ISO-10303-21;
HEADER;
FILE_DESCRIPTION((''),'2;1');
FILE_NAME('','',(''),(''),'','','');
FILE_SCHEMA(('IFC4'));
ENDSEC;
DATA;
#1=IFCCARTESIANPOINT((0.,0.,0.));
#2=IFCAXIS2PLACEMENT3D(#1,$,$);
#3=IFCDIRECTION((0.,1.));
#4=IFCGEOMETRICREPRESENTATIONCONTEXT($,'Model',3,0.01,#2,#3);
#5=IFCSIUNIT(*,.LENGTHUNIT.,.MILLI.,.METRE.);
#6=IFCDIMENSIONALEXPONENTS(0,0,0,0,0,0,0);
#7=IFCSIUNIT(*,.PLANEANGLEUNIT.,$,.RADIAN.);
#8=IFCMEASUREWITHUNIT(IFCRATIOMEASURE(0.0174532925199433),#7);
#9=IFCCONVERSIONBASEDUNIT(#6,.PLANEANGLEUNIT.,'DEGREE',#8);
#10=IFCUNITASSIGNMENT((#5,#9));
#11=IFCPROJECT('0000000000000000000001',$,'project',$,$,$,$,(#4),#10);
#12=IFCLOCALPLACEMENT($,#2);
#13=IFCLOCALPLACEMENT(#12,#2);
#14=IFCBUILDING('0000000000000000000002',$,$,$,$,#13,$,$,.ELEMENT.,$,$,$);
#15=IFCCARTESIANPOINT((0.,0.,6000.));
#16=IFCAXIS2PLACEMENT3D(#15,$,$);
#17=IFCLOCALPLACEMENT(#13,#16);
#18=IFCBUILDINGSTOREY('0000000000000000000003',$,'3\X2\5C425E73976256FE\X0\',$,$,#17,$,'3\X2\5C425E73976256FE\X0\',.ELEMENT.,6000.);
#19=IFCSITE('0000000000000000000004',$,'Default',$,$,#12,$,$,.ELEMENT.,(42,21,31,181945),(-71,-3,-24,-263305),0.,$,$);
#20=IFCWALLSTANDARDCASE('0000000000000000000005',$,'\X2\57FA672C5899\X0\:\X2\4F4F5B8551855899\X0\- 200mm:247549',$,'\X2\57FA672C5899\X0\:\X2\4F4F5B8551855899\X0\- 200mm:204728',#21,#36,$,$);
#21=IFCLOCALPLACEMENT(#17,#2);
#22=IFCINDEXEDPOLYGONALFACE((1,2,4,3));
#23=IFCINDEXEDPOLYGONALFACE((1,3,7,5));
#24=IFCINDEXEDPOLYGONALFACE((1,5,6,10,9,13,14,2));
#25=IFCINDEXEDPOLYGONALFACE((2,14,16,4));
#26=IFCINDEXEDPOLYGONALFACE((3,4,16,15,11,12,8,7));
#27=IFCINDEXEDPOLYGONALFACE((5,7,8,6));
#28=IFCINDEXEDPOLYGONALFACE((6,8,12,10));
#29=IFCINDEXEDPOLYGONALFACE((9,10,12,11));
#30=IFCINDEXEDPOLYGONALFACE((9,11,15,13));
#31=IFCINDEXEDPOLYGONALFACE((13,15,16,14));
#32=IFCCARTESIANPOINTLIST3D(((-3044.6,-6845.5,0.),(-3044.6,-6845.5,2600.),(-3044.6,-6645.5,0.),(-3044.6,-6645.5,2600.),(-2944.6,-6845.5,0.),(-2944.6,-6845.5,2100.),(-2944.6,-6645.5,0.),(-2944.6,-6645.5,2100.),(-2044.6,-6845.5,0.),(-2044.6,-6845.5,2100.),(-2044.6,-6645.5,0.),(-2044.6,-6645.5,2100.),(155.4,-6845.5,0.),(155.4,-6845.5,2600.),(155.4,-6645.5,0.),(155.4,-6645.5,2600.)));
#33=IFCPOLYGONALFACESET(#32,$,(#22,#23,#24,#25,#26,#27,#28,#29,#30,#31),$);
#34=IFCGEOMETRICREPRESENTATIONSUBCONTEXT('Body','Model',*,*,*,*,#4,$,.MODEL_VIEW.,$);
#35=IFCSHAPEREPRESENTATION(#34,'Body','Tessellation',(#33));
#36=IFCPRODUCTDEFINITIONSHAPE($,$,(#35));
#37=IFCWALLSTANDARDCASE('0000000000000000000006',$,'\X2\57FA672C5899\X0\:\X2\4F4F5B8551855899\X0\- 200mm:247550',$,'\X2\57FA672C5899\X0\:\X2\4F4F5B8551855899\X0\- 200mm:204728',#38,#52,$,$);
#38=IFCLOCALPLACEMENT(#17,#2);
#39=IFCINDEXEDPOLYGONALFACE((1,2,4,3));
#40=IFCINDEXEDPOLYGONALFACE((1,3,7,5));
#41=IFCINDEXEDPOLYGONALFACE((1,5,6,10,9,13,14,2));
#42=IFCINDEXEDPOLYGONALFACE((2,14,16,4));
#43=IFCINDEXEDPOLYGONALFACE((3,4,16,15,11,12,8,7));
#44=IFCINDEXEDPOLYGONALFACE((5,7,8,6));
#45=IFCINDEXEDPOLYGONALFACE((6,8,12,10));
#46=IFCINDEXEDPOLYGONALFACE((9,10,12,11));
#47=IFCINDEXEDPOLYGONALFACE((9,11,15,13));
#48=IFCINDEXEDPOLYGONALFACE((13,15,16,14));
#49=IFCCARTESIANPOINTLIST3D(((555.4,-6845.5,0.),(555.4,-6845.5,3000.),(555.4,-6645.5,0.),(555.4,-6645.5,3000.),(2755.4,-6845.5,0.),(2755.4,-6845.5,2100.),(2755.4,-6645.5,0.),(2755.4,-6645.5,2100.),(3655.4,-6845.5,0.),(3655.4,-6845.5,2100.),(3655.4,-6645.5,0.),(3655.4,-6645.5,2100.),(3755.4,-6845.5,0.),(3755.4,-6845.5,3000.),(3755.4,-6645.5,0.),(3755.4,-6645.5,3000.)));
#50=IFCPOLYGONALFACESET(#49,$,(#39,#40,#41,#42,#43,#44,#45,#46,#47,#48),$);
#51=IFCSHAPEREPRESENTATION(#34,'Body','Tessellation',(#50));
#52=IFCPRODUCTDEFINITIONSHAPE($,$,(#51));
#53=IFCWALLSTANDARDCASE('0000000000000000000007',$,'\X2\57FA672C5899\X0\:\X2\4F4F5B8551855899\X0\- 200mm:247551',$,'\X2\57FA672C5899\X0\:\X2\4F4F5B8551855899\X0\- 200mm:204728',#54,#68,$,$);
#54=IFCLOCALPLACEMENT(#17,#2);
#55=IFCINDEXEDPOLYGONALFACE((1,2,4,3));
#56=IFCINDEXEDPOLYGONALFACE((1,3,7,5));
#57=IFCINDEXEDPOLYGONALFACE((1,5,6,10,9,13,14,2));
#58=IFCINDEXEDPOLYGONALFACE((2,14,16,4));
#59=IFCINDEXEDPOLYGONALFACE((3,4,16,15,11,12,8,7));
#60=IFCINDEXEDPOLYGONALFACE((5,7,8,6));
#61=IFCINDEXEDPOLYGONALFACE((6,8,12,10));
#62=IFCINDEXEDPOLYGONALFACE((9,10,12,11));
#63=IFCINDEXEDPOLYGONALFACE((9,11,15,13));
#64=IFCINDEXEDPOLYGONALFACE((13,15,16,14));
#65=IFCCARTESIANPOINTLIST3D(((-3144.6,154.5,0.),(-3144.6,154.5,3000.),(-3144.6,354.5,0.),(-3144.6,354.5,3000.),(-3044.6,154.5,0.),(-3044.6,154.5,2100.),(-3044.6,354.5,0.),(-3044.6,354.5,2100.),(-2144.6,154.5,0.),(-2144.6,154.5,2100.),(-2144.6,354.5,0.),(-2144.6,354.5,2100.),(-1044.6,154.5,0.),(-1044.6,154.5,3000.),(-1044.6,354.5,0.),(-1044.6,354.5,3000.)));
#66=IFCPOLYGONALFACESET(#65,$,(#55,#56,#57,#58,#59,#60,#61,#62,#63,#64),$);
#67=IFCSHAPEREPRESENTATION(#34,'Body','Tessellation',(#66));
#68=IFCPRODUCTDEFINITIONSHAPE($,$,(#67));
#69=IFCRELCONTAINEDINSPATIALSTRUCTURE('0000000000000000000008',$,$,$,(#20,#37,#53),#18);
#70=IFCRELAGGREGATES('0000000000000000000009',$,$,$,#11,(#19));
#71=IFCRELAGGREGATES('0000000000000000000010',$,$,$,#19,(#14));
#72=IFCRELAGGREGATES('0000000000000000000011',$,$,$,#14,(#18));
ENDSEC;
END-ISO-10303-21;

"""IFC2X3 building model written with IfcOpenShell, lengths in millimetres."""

from ifc_helpers import new_model, entity, si_unit, converted_unit, direction, frame, frame_2d, origin, place, context, subcontext, project, spatial, polyline, rectangle, extrude, clip, bounded_halfspace, element, save


model = new_model("IFC2X3")

# Units and contexts
model_context = context("Model", 3, precision=0.01, world=origin(), true_north=direction((0.0, 1.0)))
body_context = subcontext(model_context, "Body", "Model", "MODEL_VIEW")
ifc_project = project(units=[si_unit("LENGTHUNIT", "METRE", prefix="MILLI"), converted_unit("PLANEANGLEUNIT", "DEGREE", entity("IfcRatioMeasure", 0.0174532925199433), si_unit("PLANEANGLEUNIT", "RADIAN"), dimensions=[0, 0, 0, 0, 0, 0, 0])], contexts=[model_context])

# Site, building, storey
site_placement = place(None, origin())
site = spatial("IfcSite", under=ifc_project, at=site_placement, Name="Default", CompositionType="ELEMENT", RefLatitude=(42, 21, 31, 181945), RefLongitude=(-71, -3, -24, -263305), RefElevation=0.0)
building_placement = place(site_placement, origin())
building = spatial("IfcBuilding", under=site, at=building_placement, CompositionType="ELEMENT")
storey_placement = place(building_placement, frame((0.0, 0.0, 6000.0)))
storey = spatial("IfcBuildingStorey", under=building, at=storey_placement, Name="3层平面图", LongName="3层平面图", CompositionType="ELEMENT", Elevation=6000.0)

# Walls, openings
wall_1_placement = place(storey_placement, frame((-3044.6, -6745.5, 0.0)))
wall_1 = element("IfcWallStandardCase", 1, at=wall_1_placement, inside=storey, Name="基本墙:住宅内墙- 200mm:247549", ObjectType="基本墙:住宅内墙- 200mm:204728", context=body_context, shape_type="Clipping", body=[
    clip(clip(clip(extrude(rectangle(XDim=3200.0, YDim=200.0, at=frame_2d((1600.0, 0.0), x_axis=(-1.0, 0.0))), origin(), (0.0, 0.0, 1.0), 2600.0), bounded_halfspace(frame((0.0, 100.0, 0.0), z_axis=(1.0, 0.0, 0.0), x_axis=(0.0, 0.0, -1.0)), True, frame((0.0, 100.0, 0.0), z_axis=(1.0, 0.0, 0.0), x_axis=(0.0, 0.0, -1.0)), polyline([(0.0, 0.0), (-2600.0, 0.0), (-2600.0, -200.0), (0.0, -200.0), (0.0, 0.0)]))), bounded_halfspace(frame((3200.0, -100.0, 0.0), z_axis=(-1.0, 0.0, 0.0), x_axis=(0.0, 0.0, -1.0)), True, frame((3200.0, -100.0, 0.0), z_axis=(-1.0, 0.0, 0.0), x_axis=(0.0, 0.0, -1.0)), polyline([(0.0, 0.0), (-2600.0, 0.0), (-2600.0, -200.0), (0.0, -200.0), (0.0, 0.0)]))), bounded_halfspace(frame((0.0, -100.0, 2600.0), z_axis=(0.0, 0.0, 1.0), x_axis=(0.0, 1.0, 0.0)), False, frame((0.0, -100.0, 2600.0), z_axis=(0.0, 0.0, 1.0), x_axis=(0.0, 1.0, 0.0)), polyline([(0.0, 0.0), (0.0, -3200.0), (200.0, -3200.0), (200.0, 0.0), (0.0, 0.0)]))),
])
opening_1_placement = place(wall_1_placement, frame((1000.0, 100.0, 0.0)))
element("IfcOpeningElement", 2, at=opening_1_placement, cuts=wall_1, ObjectType="Opening", context=body_context, shape_type="SweptSolid", body=[
    extrude(rectangle(XDim=2100.0, YDim=900.0, at=frame_2d((1050.0, 450.0), x_axis=(1.0, 0.0))), frame((0.0, 0.0, 0.0), z_axis=(0.0, -1.0, 0.0), x_axis=(0.0, 0.0, 1.0)), (0.0, 0.0, 1.0), 200.0),
])
wall_2_placement = place(storey_placement, frame((3755.4, -6745.5, 0.0), z_axis=(0.0, 0.0, 1.0), x_axis=(-1.0, 0.0, 0.0)))
wall_2 = element("IfcWallStandardCase", 3, at=wall_2_placement, inside=storey, Name="基本墙:住宅内墙- 200mm:247550", ObjectType="基本墙:住宅内墙- 200mm:204728", context=body_context, shape_type="Clipping", body=[
    clip(clip(extrude(rectangle(XDim=3200.0, YDim=200.0, at=frame_2d((1600.0, 0.0), x_axis=(-1.0, 0.0))), origin(), (0.0, 0.0, 1.0), 3000.0), bounded_halfspace(frame((0.0, -100.0, 0.0), z_axis=(-1.0, 0.0, 0.0), x_axis=(0.0, 0.0, -1.0)), False, frame((0.0, -100.0, 0.0), z_axis=(-1.0, 0.0, 0.0), x_axis=(0.0, 0.0, -1.0)), polyline([(0.0, 0.0), (-3000.0, 0.0), (-3000.0, -200.0), (0.0, -200.0), (0.0, 0.0)]))), bounded_halfspace(frame((3200.0, -100.0, 3000.0), z_axis=(-1.0, 0.0, 0.0), x_axis=(0.0, 0.0, -1.0)), True, frame((3200.0, -100.0, 3000.0), z_axis=(-1.0, 0.0, 0.0), x_axis=(0.0, 0.0, -1.0)), polyline([(0.0, 0.0), (0.0, -200.0), (3000.0, -200.0), (3000.0, 0.0), (0.0, 0.0)]))),
])
opening_2_placement = place(wall_2_placement, frame((100.0, -100.0, 0.0)))
element("IfcOpeningElement", 4, at=opening_2_placement, cuts=wall_2, ObjectType="Opening", context=body_context, shape_type="SweptSolid", body=[
    extrude(rectangle(XDim=2100.0, YDim=900.0, at=frame_2d((1050.0, 450.0), x_axis=(1.0, 0.0))), frame((0.0, 0.0, 0.0), z_axis=(0.0, 1.0, 0.0), x_axis=(0.0, 0.0, 1.0)), (0.0, 0.0, 1.0), 200.0),
])
wall_3_placement = place(storey_placement, frame((-3144.6, 254.5, 0.0)))
wall_3 = element("IfcWallStandardCase", 5, at=wall_3_placement, inside=storey, Name="基本墙:住宅内墙- 200mm:247551", ObjectType="基本墙:住宅内墙- 200mm:204728", context=body_context, shape_type="SweptSolid", body=[
    extrude(rectangle(XDim=2100.0, YDim=200.0, at=frame_2d((1050.0, 0.0), x_axis=(-1.0, 0.0))), origin(), (0.0, 0.0, 1.0), 3000.0),
])
opening_3_placement = place(wall_3_placement, frame((100.0, -100.0, 0.0)))
element("IfcOpeningElement", 6, at=opening_3_placement, cuts=wall_3, ObjectType="Opening", context=body_context, shape_type="SweptSolid", body=[
    extrude(rectangle(XDim=2100.0, YDim=900.0, at=frame_2d((1050.0, 450.0), x_axis=(1.0, 0.0))), frame((0.0, 0.0, 0.0), z_axis=(0.0, 1.0, 0.0), x_axis=(0.0, 0.0, 1.0)), (0.0, 0.0, 1.0), 200.0),
])

save(model, "model.ifc")
